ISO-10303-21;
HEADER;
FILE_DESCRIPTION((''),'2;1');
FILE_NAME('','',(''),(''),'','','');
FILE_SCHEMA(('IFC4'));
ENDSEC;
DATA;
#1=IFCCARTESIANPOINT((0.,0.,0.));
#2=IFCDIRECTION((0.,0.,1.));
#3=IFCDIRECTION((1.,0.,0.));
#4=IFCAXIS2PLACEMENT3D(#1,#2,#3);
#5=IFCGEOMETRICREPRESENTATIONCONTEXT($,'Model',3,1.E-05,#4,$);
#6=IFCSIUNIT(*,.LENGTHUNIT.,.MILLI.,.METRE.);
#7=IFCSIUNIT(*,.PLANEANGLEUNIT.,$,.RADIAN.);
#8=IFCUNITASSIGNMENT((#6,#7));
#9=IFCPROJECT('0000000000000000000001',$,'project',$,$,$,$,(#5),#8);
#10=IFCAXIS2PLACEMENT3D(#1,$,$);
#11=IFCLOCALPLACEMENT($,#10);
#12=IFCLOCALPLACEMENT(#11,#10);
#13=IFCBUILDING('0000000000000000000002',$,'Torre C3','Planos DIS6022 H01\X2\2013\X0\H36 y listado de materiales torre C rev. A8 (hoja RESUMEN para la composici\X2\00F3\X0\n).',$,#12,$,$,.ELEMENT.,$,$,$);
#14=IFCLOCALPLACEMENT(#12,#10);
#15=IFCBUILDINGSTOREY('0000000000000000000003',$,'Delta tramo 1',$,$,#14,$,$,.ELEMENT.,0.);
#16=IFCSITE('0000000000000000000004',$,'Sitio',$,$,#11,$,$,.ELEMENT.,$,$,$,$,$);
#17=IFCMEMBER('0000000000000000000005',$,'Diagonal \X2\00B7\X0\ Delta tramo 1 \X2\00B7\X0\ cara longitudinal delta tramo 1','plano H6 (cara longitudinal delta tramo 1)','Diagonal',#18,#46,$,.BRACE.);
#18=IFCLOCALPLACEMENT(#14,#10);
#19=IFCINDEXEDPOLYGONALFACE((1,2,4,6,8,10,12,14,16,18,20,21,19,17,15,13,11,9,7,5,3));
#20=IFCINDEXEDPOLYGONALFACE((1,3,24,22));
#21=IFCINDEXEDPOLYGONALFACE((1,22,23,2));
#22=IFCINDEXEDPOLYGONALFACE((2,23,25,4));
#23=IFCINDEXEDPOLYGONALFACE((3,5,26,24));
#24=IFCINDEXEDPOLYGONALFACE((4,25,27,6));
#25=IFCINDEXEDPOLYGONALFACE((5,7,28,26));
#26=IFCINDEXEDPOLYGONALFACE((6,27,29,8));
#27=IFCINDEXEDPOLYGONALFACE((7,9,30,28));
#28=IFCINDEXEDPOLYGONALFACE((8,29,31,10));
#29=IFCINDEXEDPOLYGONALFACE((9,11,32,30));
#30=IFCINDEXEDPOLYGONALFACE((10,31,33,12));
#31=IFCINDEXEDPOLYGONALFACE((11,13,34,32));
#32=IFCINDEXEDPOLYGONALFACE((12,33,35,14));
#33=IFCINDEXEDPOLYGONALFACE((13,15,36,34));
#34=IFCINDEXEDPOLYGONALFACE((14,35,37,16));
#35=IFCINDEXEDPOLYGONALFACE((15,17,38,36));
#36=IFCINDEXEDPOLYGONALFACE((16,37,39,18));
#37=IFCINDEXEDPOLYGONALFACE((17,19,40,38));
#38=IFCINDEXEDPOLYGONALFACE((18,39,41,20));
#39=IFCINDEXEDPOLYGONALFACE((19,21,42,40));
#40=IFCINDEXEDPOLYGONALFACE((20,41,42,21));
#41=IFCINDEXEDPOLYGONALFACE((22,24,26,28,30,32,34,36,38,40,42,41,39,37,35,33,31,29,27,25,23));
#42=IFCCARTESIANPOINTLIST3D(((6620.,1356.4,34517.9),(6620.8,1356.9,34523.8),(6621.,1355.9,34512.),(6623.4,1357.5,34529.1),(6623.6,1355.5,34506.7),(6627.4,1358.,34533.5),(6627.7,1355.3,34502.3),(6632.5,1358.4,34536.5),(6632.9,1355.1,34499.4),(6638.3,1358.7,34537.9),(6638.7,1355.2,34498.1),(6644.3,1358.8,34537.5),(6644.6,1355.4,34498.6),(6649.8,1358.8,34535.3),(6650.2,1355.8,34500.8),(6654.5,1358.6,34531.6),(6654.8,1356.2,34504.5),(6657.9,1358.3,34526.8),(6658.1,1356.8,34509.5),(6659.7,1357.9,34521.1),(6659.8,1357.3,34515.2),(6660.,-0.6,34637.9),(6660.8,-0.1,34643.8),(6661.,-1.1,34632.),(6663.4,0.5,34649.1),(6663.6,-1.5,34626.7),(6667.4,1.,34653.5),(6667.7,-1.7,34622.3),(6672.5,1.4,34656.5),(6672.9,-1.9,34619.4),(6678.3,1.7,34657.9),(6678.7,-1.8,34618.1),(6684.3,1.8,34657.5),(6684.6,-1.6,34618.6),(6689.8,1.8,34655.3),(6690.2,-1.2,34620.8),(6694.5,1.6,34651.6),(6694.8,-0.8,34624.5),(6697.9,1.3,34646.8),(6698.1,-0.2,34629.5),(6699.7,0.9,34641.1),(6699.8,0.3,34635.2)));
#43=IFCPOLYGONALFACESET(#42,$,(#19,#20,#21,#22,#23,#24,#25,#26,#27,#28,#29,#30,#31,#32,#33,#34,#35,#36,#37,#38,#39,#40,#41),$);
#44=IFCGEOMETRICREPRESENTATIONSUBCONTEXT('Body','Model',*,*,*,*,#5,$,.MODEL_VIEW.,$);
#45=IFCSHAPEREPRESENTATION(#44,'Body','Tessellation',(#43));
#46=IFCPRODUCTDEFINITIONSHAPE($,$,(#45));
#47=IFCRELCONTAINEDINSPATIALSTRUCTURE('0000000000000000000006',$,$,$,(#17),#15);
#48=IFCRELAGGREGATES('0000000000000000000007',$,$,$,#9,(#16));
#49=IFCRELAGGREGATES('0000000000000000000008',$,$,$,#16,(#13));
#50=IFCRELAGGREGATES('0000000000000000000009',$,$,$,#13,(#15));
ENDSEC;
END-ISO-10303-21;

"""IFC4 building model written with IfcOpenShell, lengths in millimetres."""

from ifc_helpers import new_model, si_unit, frame, origin, origin_with_axes, place, context, subcontext, project, spatial, circle, extrude, element, save


model = new_model("IFC4")

# Units and contexts
model_context = context("Model", 3, precision=1e-05, world=origin_with_axes())
body_context = subcontext(model_context, "Body", "Model", "MODEL_VIEW")
ifc_project = project(units=[si_unit("LENGTHUNIT", "METRE", prefix="MILLI"), si_unit("PLANEANGLEUNIT", "RADIAN")], contexts=[model_context])

# Site, building, storey
site_placement = place(None, origin())
site = spatial("IfcSite", under=ifc_project, at=site_placement, Name="Sitio", CompositionType="ELEMENT")
building_placement = place(site_placement, origin())
building = spatial("IfcBuilding", under=site, at=building_placement, Name="Torre C3", Description="Planos DIS6022 H01–H36 y listado de materiales torre C rev. A8 (hoja RESUMEN para la composición).", CompositionType="ELEMENT")
storey_placement = place(building_placement, origin())
storey = spatial("IfcBuildingStorey", under=building, at=storey_placement, Name="Delta tramo 1", CompositionType="ELEMENT", Elevation=0.0)

# Member
for number, where, z_axis, x_axis, name in (
    (1, (6680.0, 0.0, 34638.0), (-0.02935, 0.995684, -0.088049), (-0.999529, -0.030023, -0.006331), "Diagonal · Delta tramo 1 · cara longitudinal delta tramo 1"),
):
    element("IfcMember", number, at=place(storey_placement, frame(where, z_axis=z_axis, x_axis=x_axis)), inside=storey, Name=name, Description="plano H6 (cara longitudinal delta tramo 1)", ObjectType="Diagonal", PredefinedType="BRACE", context=body_context, shape_type="SweptSolid", body=[
        extrude(circle(Radius=20.0), None, (0.0, 0.0, 1.0), 1362.9),
    ])

save(model, "model.ifc")
